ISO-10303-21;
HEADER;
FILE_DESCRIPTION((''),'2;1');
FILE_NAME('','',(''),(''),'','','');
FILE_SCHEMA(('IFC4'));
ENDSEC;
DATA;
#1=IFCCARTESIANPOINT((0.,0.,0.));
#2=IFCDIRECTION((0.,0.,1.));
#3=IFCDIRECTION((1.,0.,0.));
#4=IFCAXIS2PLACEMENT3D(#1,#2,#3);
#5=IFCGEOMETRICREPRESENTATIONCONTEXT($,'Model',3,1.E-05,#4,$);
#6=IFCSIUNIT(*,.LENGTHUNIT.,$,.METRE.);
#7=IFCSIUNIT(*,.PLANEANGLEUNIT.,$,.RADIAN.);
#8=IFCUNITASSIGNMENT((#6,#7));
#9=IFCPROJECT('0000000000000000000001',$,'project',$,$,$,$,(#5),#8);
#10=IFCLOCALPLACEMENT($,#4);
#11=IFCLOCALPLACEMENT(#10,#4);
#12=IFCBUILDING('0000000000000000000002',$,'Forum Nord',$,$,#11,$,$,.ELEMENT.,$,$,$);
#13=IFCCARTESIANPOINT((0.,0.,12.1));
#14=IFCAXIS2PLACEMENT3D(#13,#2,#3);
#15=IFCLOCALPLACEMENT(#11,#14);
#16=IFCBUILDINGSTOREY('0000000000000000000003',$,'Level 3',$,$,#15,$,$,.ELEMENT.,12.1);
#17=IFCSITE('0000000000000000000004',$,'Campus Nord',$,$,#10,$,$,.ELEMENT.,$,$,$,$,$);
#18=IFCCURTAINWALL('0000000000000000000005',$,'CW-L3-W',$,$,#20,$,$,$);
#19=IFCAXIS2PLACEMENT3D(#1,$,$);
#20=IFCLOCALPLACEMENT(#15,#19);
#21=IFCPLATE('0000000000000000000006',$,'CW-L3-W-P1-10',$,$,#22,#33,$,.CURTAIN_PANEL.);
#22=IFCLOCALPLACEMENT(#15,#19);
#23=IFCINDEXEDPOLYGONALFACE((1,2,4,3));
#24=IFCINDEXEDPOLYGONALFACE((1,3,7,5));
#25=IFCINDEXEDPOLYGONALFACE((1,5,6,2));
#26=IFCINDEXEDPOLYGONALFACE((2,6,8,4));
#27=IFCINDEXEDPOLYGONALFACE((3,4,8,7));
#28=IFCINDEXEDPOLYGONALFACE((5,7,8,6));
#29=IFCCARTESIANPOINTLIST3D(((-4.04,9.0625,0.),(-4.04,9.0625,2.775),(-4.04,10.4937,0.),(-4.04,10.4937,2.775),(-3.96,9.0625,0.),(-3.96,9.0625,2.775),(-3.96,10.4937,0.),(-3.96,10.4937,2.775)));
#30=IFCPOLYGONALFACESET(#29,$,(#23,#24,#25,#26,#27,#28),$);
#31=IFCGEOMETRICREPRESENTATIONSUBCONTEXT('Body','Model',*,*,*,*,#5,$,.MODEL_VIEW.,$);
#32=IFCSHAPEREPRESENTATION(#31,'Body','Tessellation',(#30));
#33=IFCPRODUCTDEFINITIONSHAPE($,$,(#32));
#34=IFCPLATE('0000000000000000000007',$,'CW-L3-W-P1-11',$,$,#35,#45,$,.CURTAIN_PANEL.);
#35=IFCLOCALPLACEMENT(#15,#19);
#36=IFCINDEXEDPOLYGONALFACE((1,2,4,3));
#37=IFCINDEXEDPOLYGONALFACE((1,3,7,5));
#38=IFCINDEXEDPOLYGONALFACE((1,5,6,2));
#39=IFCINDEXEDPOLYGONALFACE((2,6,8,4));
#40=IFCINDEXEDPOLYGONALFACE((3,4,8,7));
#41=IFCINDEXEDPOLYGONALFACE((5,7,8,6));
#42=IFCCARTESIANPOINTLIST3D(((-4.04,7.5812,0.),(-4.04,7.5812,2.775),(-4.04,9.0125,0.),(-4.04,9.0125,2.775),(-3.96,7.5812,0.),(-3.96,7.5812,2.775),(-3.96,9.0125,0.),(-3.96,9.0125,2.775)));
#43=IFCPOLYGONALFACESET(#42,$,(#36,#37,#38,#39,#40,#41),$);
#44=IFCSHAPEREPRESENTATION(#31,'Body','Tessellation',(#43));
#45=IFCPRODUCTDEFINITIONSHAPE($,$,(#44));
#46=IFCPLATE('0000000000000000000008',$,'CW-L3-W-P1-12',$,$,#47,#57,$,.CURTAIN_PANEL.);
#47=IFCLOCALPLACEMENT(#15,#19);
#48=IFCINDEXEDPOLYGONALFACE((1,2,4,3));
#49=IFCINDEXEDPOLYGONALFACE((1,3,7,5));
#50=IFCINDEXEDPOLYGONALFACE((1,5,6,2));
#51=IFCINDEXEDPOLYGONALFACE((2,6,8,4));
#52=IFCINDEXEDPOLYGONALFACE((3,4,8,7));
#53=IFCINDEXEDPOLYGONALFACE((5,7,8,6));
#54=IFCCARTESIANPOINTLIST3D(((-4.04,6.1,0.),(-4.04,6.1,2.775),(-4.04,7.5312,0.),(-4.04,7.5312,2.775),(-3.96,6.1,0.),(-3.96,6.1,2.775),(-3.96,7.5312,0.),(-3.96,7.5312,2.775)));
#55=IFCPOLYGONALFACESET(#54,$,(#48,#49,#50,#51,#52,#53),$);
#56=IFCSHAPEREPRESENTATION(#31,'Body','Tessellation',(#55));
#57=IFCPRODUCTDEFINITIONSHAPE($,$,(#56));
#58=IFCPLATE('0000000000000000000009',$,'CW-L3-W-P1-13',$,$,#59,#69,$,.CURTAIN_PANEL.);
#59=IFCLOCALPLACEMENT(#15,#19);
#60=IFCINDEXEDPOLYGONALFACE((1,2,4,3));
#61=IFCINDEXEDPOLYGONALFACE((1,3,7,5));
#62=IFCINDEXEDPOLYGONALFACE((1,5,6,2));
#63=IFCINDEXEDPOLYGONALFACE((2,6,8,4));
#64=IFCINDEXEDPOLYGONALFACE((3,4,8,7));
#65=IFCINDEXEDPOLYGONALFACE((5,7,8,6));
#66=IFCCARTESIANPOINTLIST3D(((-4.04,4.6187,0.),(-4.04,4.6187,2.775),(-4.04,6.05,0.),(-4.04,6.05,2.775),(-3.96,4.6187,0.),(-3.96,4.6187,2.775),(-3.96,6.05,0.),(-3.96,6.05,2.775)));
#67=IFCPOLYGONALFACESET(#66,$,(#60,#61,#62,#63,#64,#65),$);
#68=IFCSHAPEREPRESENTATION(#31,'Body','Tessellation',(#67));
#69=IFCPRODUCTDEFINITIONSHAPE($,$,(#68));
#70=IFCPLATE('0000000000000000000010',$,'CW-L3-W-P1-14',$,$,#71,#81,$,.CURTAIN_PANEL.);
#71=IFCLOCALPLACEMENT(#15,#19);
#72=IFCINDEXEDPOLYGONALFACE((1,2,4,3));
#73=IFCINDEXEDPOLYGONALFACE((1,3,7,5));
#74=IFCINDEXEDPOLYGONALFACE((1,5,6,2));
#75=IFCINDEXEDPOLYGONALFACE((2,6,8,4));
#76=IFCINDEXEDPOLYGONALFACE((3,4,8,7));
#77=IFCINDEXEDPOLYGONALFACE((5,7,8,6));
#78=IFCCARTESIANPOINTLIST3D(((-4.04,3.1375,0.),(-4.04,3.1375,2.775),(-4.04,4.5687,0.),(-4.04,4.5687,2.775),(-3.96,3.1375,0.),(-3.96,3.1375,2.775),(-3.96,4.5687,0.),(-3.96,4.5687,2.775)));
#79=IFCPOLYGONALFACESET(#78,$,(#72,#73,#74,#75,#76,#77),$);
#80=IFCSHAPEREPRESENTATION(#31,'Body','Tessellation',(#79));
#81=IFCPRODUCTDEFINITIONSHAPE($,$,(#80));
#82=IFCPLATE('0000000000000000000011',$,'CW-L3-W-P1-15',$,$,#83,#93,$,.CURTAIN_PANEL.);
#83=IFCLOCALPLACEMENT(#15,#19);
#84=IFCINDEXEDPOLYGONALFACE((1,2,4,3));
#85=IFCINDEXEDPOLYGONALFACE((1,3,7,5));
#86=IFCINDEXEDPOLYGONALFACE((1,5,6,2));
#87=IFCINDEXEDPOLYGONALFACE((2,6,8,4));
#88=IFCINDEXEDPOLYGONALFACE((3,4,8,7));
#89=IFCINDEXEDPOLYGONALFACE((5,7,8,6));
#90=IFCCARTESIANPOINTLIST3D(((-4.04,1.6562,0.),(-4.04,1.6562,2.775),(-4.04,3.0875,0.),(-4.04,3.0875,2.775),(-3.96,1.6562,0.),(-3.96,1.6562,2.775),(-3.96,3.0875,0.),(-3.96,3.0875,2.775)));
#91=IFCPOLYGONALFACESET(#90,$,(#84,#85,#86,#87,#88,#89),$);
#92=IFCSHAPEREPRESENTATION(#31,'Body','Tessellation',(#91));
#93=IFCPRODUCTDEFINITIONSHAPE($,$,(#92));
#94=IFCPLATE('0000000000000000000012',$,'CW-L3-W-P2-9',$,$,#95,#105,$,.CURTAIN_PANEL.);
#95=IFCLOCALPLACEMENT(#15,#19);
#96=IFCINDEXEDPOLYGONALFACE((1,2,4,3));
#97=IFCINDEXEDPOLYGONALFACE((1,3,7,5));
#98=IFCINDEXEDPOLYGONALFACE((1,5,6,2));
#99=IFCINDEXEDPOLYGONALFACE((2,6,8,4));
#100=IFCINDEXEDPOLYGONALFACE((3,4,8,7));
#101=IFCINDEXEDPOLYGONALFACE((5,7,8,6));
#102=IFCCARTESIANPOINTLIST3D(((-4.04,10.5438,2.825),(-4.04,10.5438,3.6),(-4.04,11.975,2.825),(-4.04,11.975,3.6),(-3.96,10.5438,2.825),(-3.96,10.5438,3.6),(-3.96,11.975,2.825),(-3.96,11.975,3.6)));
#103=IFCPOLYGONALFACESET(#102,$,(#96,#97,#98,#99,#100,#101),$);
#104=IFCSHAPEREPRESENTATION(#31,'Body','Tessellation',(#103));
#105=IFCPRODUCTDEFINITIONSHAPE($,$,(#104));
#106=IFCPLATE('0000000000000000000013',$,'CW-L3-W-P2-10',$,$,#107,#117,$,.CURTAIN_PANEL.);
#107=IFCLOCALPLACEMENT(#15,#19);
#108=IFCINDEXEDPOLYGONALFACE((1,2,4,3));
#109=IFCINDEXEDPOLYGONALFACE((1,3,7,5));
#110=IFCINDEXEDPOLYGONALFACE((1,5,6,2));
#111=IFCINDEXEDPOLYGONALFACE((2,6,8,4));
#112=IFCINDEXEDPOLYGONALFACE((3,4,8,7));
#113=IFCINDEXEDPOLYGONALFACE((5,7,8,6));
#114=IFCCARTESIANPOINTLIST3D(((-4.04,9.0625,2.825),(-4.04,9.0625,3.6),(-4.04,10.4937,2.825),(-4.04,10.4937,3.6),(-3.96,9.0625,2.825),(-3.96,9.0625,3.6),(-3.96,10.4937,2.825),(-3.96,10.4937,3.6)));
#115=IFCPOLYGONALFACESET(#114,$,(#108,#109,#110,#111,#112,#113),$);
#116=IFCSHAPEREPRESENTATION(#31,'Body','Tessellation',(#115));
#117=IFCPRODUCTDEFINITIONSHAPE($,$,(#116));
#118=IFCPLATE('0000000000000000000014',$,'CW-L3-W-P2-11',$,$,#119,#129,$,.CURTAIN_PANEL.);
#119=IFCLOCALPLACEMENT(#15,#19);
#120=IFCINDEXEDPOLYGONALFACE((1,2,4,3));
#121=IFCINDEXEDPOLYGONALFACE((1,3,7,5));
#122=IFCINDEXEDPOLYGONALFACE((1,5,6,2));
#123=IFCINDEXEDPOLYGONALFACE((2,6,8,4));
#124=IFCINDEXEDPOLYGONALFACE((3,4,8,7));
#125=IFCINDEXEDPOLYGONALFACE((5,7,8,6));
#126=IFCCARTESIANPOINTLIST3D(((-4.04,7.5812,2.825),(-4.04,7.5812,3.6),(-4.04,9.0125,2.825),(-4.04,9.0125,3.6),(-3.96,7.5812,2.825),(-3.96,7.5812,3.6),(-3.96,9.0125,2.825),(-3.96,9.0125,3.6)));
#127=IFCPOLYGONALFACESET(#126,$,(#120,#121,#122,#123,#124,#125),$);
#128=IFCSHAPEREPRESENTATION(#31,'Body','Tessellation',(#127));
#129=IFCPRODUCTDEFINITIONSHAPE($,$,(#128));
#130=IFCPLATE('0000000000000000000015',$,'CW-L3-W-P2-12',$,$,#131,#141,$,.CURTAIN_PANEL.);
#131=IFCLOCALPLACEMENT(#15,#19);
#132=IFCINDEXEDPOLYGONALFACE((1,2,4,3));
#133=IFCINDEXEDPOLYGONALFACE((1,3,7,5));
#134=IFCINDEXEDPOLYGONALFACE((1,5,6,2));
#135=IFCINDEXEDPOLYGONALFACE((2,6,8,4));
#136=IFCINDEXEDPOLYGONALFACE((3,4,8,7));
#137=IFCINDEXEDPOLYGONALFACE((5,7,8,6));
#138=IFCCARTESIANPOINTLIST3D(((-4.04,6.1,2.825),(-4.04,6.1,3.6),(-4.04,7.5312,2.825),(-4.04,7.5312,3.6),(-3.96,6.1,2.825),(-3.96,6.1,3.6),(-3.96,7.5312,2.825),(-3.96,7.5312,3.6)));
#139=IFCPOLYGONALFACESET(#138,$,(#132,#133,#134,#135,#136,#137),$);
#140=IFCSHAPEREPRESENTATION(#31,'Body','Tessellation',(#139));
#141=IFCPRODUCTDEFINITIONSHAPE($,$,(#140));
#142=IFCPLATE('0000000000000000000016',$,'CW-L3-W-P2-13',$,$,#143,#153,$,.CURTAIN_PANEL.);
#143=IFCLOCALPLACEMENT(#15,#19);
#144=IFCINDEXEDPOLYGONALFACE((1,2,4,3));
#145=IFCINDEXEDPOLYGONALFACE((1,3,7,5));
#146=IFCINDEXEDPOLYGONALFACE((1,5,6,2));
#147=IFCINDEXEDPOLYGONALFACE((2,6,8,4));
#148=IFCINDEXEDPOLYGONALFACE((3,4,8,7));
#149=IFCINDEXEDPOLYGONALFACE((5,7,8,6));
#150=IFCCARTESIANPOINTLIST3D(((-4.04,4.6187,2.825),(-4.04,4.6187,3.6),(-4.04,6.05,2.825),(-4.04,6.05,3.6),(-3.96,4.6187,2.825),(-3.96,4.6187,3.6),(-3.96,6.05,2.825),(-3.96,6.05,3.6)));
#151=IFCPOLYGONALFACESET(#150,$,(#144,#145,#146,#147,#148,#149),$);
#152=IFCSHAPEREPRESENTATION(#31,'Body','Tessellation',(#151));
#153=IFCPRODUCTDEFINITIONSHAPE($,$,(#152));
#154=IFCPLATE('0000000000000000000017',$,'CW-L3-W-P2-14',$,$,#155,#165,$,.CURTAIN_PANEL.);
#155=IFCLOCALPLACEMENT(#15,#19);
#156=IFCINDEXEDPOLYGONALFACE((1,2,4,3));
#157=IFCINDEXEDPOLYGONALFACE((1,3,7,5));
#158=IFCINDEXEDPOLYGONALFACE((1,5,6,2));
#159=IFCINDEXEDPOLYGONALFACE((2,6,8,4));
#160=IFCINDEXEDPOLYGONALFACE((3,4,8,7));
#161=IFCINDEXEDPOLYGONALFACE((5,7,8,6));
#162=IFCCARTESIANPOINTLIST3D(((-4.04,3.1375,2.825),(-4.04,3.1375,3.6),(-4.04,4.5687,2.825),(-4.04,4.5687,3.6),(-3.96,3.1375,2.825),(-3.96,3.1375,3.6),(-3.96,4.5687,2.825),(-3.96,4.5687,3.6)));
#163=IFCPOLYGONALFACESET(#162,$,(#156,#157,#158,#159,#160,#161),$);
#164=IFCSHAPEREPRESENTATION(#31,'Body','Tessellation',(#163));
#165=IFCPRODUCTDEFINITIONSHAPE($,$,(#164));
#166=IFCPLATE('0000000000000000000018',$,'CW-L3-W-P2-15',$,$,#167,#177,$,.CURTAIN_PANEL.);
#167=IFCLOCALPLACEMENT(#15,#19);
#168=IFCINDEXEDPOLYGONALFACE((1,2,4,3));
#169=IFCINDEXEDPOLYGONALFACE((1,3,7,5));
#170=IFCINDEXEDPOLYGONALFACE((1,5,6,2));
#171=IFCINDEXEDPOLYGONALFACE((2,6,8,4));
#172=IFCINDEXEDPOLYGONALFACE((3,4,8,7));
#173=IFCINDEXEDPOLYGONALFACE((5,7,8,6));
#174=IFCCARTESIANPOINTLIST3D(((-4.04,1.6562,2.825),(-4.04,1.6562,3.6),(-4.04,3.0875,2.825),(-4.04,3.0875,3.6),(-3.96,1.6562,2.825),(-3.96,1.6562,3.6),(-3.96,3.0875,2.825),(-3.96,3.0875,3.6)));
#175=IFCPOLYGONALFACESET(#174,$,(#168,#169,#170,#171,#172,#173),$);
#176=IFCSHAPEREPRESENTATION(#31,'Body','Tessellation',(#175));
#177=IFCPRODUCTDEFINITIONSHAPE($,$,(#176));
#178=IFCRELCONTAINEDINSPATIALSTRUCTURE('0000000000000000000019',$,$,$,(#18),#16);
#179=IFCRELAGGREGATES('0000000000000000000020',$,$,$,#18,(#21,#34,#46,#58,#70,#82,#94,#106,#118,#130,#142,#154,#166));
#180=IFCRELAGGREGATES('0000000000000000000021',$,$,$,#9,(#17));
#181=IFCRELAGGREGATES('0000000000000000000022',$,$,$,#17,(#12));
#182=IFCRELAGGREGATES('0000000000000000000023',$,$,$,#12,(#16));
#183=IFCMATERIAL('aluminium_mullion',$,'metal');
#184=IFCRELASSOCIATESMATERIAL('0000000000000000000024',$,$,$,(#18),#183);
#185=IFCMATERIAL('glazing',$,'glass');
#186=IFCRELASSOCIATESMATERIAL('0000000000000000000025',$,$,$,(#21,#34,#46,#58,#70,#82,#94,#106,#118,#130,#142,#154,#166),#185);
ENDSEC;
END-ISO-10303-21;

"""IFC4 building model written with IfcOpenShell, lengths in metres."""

from ifc_helpers import new_model, si_unit, frame, frame_2d, origin_with_axes, place, context, subcontext, project, spatial, rectangle, extrude, material, element, aggregate, save


model = new_model("IFC4")

# Units and contexts
model_context = context("Model", 3, precision=1e-05, world=origin_with_axes())
body_context = subcontext(model_context, "Body", "Model", "MODEL_VIEW")
ifc_project = project(units=[si_unit("LENGTHUNIT", "METRE"), si_unit("PLANEANGLEUNIT", "RADIAN")], contexts=[model_context])

# Site, building, storey
site_placement = place(None, origin_with_axes())
site = spatial("IfcSite", under=ifc_project, at=site_placement, Name="Campus Nord", CompositionType="ELEMENT")
building_placement = place(site_placement, origin_with_axes())
building = spatial("IfcBuilding", under=site, at=building_placement, Name="Forum Nord", CompositionType="ELEMENT")
storey_placement = place(building_placement, frame((0.0, 0.0, 12.1), z_axis=(0.0, 0.0, 1.0), x_axis=(1.0, 0.0, 0.0)))
storey = spatial("IfcBuildingStorey", under=building, at=storey_placement, Name="Level 3", CompositionType="ELEMENT", Elevation=12.1)

# Curtain wall, plates
ifc_material_1 = material(Name="aluminium_mullion", Category="metal")
curtain_wall_placement = place(storey_placement, origin_with_axes())
curtain_wall = element("IfcCurtainWall", 1, at=curtain_wall_placement, inside=storey, material=ifc_material_1, Name="CW-L3-W")
ifc_material_2 = material(Name="glazing", Category="glass")
plate_1_placement = place(storey_placement, frame((-4.0, 10.4938, 0.0), z_axis=(0.0, 0.0, 1.0), x_axis=(0.0, -1.0, 0.0)))
plate_1 = element("IfcPlate", 2, at=plate_1_placement, material=ifc_material_2, Name="CW-L3-W-P1-10", PredefinedType="CURTAIN_PANEL", context=body_context, shape_type="SweptSolid", body=[
    extrude(rectangle(XDim=1.4312, YDim=0.08, at=frame_2d((0.7156, 0.0), x_axis=(1.0, 0.0))), origin_with_axes(), (0.0, 0.0, 1.0), 2.775),
])
plate_2_placement = place(storey_placement, frame((-4.0, 9.0125, 0.0), z_axis=(0.0, 0.0, 1.0), x_axis=(0.0, -1.0, 0.0)))
plate_2 = element("IfcPlate", 3, at=plate_2_placement, material=ifc_material_2, Name="CW-L3-W-P1-11", PredefinedType="CURTAIN_PANEL", context=body_context, shape_type="SweptSolid", body=[
    extrude(rectangle(XDim=1.4312, YDim=0.08, at=frame_2d((0.7156, 0.0), x_axis=(1.0, 0.0))), origin_with_axes(), (0.0, 0.0, 1.0), 2.775),
])
plate_3_placement = place(storey_placement, frame((-4.0, 7.5312, 0.0), z_axis=(0.0, 0.0, 1.0), x_axis=(0.0, -1.0, 0.0)))
plate_3 = element("IfcPlate", 4, at=plate_3_placement, material=ifc_material_2, Name="CW-L3-W-P1-12", PredefinedType="CURTAIN_PANEL", context=body_context, shape_type="SweptSolid", body=[
    extrude(rectangle(XDim=1.4312, YDim=0.08, at=frame_2d((0.7156, 0.0), x_axis=(1.0, 0.0))), origin_with_axes(), (0.0, 0.0, 1.0), 2.775),
])
plate_4_placement = place(storey_placement, frame((-4.0, 6.05, 0.0), z_axis=(0.0, 0.0, 1.0), x_axis=(0.0, -1.0, 0.0)))
plate_4 = element("IfcPlate", 5, at=plate_4_placement, material=ifc_material_2, Name="CW-L3-W-P1-13", PredefinedType="CURTAIN_PANEL", context=body_context, shape_type="SweptSolid", body=[
    extrude(rectangle(XDim=1.4312, YDim=0.08, at=frame_2d((0.7156, 0.0), x_axis=(1.0, 0.0))), origin_with_axes(), (0.0, 0.0, 1.0), 2.775),
])
plate_5_placement = place(storey_placement, frame((-4.0, 4.5687, 0.0), z_axis=(0.0, 0.0, 1.0), x_axis=(0.0, -1.0, 0.0)))
plate_5 = element("IfcPlate", 6, at=plate_5_placement, material=ifc_material_2, Name="CW-L3-W-P1-14", PredefinedType="CURTAIN_PANEL", context=body_context, shape_type="SweptSolid", body=[
    extrude(rectangle(XDim=1.4312, YDim=0.08, at=frame_2d((0.7156, 0.0), x_axis=(1.0, 0.0))), origin_with_axes(), (0.0, 0.0, 1.0), 2.775),
])
plate_6_placement = place(storey_placement, frame((-4.0, 3.0875, 0.0), z_axis=(0.0, 0.0, 1.0), x_axis=(0.0, -1.0, 0.0)))
plate_6 = element("IfcPlate", 7, at=plate_6_placement, material=ifc_material_2, Name="CW-L3-W-P1-15", PredefinedType="CURTAIN_PANEL", context=body_context, shape_type="SweptSolid", body=[
    extrude(rectangle(XDim=1.4312, YDim=0.08, at=frame_2d((0.7156, 0.0), x_axis=(1.0, 0.0))), origin_with_axes(), (0.0, 0.0, 1.0), 2.775),
])
plate_7_placement = place(storey_placement, frame((-4.0, 11.975, 2.825), z_axis=(0.0, 0.0, 1.0), x_axis=(0.0, -1.0, 0.0)))
plate_7 = element("IfcPlate", 8, at=plate_7_placement, material=ifc_material_2, Name="CW-L3-W-P2-9", PredefinedType="CURTAIN_PANEL", context=body_context, shape_type="SweptSolid", body=[
    extrude(rectangle(XDim=1.4312, YDim=0.08, at=frame_2d((0.7156, 0.0), x_axis=(1.0, 0.0))), origin_with_axes(), (0.0, 0.0, 1.0), 0.775),
])
plate_8_placement = place(storey_placement, frame((-4.0, 10.4938, 2.825), z_axis=(0.0, 0.0, 1.0), x_axis=(0.0, -1.0, 0.0)))
plate_8 = element("IfcPlate", 9, at=plate_8_placement, material=ifc_material_2, Name="CW-L3-W-P2-10", PredefinedType="CURTAIN_PANEL", context=body_context, shape_type="SweptSolid", body=[
    extrude(rectangle(XDim=1.4312, YDim=0.08, at=frame_2d((0.7156, 0.0), x_axis=(1.0, 0.0))), origin_with_axes(), (0.0, 0.0, 1.0), 0.775),
])
plate_9_placement = place(storey_placement, frame((-4.0, 9.0125, 2.825), z_axis=(0.0, 0.0, 1.0), x_axis=(0.0, -1.0, 0.0)))
plate_9 = element("IfcPlate", 10, at=plate_9_placement, material=ifc_material_2, Name="CW-L3-W-P2-11", PredefinedType="CURTAIN_PANEL", context=body_context, shape_type="SweptSolid", body=[
    extrude(rectangle(XDim=1.4312, YDim=0.08, at=frame_2d((0.7156, 0.0), x_axis=(1.0, 0.0))), origin_with_axes(), (0.0, 0.0, 1.0), 0.775),
])
plate_10_placement = place(storey_placement, frame((-4.0, 7.5312, 2.825), z_axis=(0.0, 0.0, 1.0), x_axis=(0.0, -1.0, 0.0)))
plate_10 = element("IfcPlate", 11, at=plate_10_placement, material=ifc_material_2, Name="CW-L3-W-P2-12", PredefinedType="CURTAIN_PANEL", context=body_context, shape_type="SweptSolid", body=[
    extrude(rectangle(XDim=1.4312, YDim=0.08, at=frame_2d((0.7156, 0.0), x_axis=(1.0, 0.0))), origin_with_axes(), (0.0, 0.0, 1.0), 0.775),
])
plate_11_placement = place(storey_placement, frame((-4.0, 6.05, 2.825), z_axis=(0.0, 0.0, 1.0), x_axis=(0.0, -1.0, 0.0)))
plate_11 = element("IfcPlate", 12, at=plate_11_placement, material=ifc_material_2, Name="CW-L3-W-P2-13", PredefinedType="CURTAIN_PANEL", context=body_context, shape_type="SweptSolid", body=[
    extrude(rectangle(XDim=1.4312, YDim=0.08, at=frame_2d((0.7156, 0.0), x_axis=(1.0, 0.0))), origin_with_axes(), (0.0, 0.0, 1.0), 0.775),
])
plate_12_placement = place(storey_placement, frame((-4.0, 4.5687, 2.825), z_axis=(0.0, 0.0, 1.0), x_axis=(0.0, -1.0, 0.0)))
plate_12 = element("IfcPlate", 13, at=plate_12_placement, material=ifc_material_2, Name="CW-L3-W-P2-14", PredefinedType="CURTAIN_PANEL", context=body_context, shape_type="SweptSolid", body=[
    extrude(rectangle(XDim=1.4312, YDim=0.08, at=frame_2d((0.7156, 0.0), x_axis=(1.0, 0.0))), origin_with_axes(), (0.0, 0.0, 1.0), 0.775),
])
plate_13_placement = place(storey_placement, frame((-4.0, 3.0875, 2.825), z_axis=(0.0, 0.0, 1.0), x_axis=(0.0, -1.0, 0.0)))
plate_13 = element("IfcPlate", 14, at=plate_13_placement, material=ifc_material_2, Name="CW-L3-W-P2-15", PredefinedType="CURTAIN_PANEL", context=body_context, shape_type="SweptSolid", body=[
    extrude(rectangle(XDim=1.4312, YDim=0.08, at=frame_2d((0.7156, 0.0), x_axis=(1.0, 0.0))), origin_with_axes(), (0.0, 0.0, 1.0), 0.775),
])
aggregate(curtain_wall, [plate_1, plate_2, plate_3, plate_4, plate_5, plate_6, plate_7, plate_8, plate_9, plate_10, plate_11, plate_12, plate_13])

save(model, "model.ifc")
